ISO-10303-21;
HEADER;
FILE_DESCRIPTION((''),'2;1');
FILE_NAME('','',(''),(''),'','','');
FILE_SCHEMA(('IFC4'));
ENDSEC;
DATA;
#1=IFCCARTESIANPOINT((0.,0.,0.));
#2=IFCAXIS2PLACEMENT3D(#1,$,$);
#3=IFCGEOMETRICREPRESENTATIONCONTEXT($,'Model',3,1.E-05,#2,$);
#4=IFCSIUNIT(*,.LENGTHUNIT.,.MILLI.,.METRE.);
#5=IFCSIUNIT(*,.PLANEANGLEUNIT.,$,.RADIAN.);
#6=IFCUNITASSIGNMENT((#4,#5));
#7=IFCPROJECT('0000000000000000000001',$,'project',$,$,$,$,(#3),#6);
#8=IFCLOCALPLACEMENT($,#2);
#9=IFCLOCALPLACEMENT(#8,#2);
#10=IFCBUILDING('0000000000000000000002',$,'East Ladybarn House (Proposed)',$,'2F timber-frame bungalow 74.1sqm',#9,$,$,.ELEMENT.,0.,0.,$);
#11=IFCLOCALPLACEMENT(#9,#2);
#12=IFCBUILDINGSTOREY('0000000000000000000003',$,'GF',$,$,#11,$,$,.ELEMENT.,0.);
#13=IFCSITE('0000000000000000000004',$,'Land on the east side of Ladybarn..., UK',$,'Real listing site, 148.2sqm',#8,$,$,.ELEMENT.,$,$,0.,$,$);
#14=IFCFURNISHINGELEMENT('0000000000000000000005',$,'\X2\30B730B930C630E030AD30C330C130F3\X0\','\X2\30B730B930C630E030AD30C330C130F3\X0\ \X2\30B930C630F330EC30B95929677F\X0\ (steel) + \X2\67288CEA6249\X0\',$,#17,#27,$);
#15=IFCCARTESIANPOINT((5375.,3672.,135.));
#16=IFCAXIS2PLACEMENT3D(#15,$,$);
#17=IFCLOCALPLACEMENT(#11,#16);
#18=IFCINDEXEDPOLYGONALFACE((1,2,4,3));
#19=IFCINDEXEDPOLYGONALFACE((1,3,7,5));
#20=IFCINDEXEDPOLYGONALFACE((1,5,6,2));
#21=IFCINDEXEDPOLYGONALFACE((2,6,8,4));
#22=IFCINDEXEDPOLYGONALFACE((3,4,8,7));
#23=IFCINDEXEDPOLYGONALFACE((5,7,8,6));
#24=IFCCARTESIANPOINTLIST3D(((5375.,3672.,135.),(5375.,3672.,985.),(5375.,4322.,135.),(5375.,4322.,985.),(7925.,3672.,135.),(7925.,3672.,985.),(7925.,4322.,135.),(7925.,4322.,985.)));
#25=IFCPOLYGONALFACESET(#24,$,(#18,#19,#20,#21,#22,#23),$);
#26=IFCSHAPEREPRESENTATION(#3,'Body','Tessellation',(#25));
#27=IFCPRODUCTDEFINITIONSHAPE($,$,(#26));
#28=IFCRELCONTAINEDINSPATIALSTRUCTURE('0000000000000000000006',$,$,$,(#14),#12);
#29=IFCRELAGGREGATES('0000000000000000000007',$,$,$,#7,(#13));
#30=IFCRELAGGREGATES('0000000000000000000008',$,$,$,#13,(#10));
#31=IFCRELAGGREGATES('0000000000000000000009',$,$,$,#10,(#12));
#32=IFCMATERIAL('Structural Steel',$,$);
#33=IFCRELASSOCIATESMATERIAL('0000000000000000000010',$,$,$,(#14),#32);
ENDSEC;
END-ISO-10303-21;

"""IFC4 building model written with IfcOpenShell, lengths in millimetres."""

from ifc_helpers import new_model, si_unit, frame, frame_2d, origin, place, context, project, spatial, rectangle, extrude, material, element, save


model = new_model("IFC4")

# Units and contexts
model_context = context("Model", 3, precision=1e-05, world=origin())
ifc_project = project(units=[si_unit("LENGTHUNIT", "METRE", prefix="MILLI"), si_unit("PLANEANGLEUNIT", "RADIAN")], contexts=[model_context])

# Site, building, storey
site_placement = place(None, origin())
site = spatial("IfcSite", under=ifc_project, at=site_placement, Name="Land on the east side of Ladybarn..., UK", ObjectType="Real listing site, 148.2sqm", CompositionType="ELEMENT", RefElevation=0.0)
building_placement = place(site_placement, origin())
building = spatial("IfcBuilding", under=site, at=building_placement, Name="East Ladybarn House (Proposed)", ObjectType="2F timber-frame bungalow 74.1sqm", CompositionType="ELEMENT", ElevationOfRefHeight=0.0, ElevationOfTerrain=0.0)
storey_placement = place(building_placement, origin())
storey = spatial("IfcBuildingStorey", under=building, at=storey_placement, Name="GF", CompositionType="ELEMENT", Elevation=0.0)

# Furnishing element
ifc_material_1 = material(Name="Structural Steel")
furnishing_1_placement = place(storey_placement, frame((5375.0, 3672.0, 135.0)))
element("IfcFurnishingElement", 1, at=furnishing_1_placement, inside=storey, material=ifc_material_1, Name="システムキッチン", Description="システムキッチン ステンレス天板 (steel) + 木質扉", context=model_context, shape_type="SweptSolid", body=[
    extrude(rectangle(XDim=2550.0, YDim=650.0, at=frame_2d((1275.0, 325.0))), frame((5375.0, 3672.0, 135.0)), (0.0, 0.0, 1.0), 850.0),
])

save(model, "model.ifc")
